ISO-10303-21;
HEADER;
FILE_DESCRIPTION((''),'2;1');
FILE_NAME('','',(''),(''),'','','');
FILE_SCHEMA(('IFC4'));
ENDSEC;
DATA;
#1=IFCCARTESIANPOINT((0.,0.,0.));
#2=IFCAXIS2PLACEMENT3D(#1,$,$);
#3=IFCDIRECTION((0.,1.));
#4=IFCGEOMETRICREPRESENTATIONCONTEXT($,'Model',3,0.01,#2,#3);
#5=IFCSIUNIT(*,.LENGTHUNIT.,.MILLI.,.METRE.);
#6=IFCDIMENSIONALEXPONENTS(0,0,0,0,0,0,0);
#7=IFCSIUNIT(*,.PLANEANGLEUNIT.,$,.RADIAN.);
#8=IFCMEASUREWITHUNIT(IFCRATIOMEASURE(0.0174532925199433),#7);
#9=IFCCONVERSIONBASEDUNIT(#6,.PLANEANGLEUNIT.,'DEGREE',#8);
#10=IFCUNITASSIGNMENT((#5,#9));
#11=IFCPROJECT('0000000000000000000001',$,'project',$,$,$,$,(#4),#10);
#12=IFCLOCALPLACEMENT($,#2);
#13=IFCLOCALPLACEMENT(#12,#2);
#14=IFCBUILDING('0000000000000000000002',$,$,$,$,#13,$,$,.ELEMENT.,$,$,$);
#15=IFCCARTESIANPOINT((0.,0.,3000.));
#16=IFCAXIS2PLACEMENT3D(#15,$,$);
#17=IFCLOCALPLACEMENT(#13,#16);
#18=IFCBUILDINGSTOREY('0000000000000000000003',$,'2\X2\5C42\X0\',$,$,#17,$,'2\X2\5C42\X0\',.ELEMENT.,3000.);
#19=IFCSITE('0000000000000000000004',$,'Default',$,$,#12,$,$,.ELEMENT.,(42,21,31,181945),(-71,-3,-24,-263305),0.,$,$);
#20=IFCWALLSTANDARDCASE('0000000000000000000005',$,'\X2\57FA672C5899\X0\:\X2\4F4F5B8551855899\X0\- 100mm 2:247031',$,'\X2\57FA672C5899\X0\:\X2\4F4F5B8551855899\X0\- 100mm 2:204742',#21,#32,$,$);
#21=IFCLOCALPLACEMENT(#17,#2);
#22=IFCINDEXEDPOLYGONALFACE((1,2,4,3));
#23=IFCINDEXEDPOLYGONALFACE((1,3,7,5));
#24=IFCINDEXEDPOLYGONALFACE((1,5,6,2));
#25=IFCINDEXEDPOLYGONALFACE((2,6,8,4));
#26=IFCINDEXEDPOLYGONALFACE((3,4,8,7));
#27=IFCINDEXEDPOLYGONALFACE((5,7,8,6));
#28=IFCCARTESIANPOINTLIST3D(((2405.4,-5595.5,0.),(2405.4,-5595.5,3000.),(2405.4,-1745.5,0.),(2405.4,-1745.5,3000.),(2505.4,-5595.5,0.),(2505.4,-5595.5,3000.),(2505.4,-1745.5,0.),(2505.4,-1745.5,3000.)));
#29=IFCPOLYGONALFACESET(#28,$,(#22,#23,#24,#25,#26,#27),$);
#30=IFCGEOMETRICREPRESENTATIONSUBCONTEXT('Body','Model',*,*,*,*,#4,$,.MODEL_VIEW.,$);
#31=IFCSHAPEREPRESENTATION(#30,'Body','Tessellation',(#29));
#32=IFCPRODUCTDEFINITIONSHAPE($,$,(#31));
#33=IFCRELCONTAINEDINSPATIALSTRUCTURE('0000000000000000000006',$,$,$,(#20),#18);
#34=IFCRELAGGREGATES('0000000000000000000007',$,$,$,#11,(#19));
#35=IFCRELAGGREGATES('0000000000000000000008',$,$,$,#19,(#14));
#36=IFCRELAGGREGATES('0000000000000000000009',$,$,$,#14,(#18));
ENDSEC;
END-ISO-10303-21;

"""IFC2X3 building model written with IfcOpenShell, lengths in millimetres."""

from ifc_helpers import new_model, entity, si_unit, converted_unit, direction, frame, frame_2d, origin, place, context, subcontext, project, spatial, rectangle, extrude, element, save


model = new_model("IFC2X3")

# Units and contexts
model_context = context("Model", 3, precision=0.01, world=origin(), true_north=direction((0.0, 1.0)))
body_context = subcontext(model_context, "Body", "Model", "MODEL_VIEW")
ifc_project = project(units=[si_unit("LENGTHUNIT", "METRE", prefix="MILLI"), converted_unit("PLANEANGLEUNIT", "DEGREE", entity("IfcRatioMeasure", 0.0174532925199433), si_unit("PLANEANGLEUNIT", "RADIAN"), dimensions=[0, 0, 0, 0, 0, 0, 0])], contexts=[model_context])

# Site, building, storey
site_placement = place(None, origin())
site = spatial("IfcSite", under=ifc_project, at=site_placement, Name="Default", CompositionType="ELEMENT", RefLatitude=(42, 21, 31, 181945), RefLongitude=(-71, -3, -24, -263305), RefElevation=0.0)
building_placement = place(site_placement, origin())
building = spatial("IfcBuilding", under=site, at=building_placement, CompositionType="ELEMENT")
storey_placement = place(building_placement, frame((0.0, 0.0, 3000.0)))
storey = spatial("IfcBuildingStorey", under=building, at=storey_placement, Name="2层", LongName="2层", CompositionType="ELEMENT", Elevation=3000.0)

# Wall
wall_placement = place(storey_placement, frame((2455.4, -1745.5, 0.0), z_axis=(0.0, 0.0, 1.0), x_axis=(0.0, -1.0, 0.0)))
element("IfcWallStandardCase", 1, at=wall_placement, inside=storey, Name="基本墙:住宅内墙- 100mm 2:247031", ObjectType="基本墙:住宅内墙- 100mm 2:204742", context=body_context, shape_type="SweptSolid", body=[
    extrude(rectangle(XDim=3850.0, YDim=100.0, at=frame_2d((1925.0, 0.0), x_axis=(-1.0, 0.0))), origin(), (0.0, 0.0, 1.0), 3000.0),
])

save(model, "model.ifc")
